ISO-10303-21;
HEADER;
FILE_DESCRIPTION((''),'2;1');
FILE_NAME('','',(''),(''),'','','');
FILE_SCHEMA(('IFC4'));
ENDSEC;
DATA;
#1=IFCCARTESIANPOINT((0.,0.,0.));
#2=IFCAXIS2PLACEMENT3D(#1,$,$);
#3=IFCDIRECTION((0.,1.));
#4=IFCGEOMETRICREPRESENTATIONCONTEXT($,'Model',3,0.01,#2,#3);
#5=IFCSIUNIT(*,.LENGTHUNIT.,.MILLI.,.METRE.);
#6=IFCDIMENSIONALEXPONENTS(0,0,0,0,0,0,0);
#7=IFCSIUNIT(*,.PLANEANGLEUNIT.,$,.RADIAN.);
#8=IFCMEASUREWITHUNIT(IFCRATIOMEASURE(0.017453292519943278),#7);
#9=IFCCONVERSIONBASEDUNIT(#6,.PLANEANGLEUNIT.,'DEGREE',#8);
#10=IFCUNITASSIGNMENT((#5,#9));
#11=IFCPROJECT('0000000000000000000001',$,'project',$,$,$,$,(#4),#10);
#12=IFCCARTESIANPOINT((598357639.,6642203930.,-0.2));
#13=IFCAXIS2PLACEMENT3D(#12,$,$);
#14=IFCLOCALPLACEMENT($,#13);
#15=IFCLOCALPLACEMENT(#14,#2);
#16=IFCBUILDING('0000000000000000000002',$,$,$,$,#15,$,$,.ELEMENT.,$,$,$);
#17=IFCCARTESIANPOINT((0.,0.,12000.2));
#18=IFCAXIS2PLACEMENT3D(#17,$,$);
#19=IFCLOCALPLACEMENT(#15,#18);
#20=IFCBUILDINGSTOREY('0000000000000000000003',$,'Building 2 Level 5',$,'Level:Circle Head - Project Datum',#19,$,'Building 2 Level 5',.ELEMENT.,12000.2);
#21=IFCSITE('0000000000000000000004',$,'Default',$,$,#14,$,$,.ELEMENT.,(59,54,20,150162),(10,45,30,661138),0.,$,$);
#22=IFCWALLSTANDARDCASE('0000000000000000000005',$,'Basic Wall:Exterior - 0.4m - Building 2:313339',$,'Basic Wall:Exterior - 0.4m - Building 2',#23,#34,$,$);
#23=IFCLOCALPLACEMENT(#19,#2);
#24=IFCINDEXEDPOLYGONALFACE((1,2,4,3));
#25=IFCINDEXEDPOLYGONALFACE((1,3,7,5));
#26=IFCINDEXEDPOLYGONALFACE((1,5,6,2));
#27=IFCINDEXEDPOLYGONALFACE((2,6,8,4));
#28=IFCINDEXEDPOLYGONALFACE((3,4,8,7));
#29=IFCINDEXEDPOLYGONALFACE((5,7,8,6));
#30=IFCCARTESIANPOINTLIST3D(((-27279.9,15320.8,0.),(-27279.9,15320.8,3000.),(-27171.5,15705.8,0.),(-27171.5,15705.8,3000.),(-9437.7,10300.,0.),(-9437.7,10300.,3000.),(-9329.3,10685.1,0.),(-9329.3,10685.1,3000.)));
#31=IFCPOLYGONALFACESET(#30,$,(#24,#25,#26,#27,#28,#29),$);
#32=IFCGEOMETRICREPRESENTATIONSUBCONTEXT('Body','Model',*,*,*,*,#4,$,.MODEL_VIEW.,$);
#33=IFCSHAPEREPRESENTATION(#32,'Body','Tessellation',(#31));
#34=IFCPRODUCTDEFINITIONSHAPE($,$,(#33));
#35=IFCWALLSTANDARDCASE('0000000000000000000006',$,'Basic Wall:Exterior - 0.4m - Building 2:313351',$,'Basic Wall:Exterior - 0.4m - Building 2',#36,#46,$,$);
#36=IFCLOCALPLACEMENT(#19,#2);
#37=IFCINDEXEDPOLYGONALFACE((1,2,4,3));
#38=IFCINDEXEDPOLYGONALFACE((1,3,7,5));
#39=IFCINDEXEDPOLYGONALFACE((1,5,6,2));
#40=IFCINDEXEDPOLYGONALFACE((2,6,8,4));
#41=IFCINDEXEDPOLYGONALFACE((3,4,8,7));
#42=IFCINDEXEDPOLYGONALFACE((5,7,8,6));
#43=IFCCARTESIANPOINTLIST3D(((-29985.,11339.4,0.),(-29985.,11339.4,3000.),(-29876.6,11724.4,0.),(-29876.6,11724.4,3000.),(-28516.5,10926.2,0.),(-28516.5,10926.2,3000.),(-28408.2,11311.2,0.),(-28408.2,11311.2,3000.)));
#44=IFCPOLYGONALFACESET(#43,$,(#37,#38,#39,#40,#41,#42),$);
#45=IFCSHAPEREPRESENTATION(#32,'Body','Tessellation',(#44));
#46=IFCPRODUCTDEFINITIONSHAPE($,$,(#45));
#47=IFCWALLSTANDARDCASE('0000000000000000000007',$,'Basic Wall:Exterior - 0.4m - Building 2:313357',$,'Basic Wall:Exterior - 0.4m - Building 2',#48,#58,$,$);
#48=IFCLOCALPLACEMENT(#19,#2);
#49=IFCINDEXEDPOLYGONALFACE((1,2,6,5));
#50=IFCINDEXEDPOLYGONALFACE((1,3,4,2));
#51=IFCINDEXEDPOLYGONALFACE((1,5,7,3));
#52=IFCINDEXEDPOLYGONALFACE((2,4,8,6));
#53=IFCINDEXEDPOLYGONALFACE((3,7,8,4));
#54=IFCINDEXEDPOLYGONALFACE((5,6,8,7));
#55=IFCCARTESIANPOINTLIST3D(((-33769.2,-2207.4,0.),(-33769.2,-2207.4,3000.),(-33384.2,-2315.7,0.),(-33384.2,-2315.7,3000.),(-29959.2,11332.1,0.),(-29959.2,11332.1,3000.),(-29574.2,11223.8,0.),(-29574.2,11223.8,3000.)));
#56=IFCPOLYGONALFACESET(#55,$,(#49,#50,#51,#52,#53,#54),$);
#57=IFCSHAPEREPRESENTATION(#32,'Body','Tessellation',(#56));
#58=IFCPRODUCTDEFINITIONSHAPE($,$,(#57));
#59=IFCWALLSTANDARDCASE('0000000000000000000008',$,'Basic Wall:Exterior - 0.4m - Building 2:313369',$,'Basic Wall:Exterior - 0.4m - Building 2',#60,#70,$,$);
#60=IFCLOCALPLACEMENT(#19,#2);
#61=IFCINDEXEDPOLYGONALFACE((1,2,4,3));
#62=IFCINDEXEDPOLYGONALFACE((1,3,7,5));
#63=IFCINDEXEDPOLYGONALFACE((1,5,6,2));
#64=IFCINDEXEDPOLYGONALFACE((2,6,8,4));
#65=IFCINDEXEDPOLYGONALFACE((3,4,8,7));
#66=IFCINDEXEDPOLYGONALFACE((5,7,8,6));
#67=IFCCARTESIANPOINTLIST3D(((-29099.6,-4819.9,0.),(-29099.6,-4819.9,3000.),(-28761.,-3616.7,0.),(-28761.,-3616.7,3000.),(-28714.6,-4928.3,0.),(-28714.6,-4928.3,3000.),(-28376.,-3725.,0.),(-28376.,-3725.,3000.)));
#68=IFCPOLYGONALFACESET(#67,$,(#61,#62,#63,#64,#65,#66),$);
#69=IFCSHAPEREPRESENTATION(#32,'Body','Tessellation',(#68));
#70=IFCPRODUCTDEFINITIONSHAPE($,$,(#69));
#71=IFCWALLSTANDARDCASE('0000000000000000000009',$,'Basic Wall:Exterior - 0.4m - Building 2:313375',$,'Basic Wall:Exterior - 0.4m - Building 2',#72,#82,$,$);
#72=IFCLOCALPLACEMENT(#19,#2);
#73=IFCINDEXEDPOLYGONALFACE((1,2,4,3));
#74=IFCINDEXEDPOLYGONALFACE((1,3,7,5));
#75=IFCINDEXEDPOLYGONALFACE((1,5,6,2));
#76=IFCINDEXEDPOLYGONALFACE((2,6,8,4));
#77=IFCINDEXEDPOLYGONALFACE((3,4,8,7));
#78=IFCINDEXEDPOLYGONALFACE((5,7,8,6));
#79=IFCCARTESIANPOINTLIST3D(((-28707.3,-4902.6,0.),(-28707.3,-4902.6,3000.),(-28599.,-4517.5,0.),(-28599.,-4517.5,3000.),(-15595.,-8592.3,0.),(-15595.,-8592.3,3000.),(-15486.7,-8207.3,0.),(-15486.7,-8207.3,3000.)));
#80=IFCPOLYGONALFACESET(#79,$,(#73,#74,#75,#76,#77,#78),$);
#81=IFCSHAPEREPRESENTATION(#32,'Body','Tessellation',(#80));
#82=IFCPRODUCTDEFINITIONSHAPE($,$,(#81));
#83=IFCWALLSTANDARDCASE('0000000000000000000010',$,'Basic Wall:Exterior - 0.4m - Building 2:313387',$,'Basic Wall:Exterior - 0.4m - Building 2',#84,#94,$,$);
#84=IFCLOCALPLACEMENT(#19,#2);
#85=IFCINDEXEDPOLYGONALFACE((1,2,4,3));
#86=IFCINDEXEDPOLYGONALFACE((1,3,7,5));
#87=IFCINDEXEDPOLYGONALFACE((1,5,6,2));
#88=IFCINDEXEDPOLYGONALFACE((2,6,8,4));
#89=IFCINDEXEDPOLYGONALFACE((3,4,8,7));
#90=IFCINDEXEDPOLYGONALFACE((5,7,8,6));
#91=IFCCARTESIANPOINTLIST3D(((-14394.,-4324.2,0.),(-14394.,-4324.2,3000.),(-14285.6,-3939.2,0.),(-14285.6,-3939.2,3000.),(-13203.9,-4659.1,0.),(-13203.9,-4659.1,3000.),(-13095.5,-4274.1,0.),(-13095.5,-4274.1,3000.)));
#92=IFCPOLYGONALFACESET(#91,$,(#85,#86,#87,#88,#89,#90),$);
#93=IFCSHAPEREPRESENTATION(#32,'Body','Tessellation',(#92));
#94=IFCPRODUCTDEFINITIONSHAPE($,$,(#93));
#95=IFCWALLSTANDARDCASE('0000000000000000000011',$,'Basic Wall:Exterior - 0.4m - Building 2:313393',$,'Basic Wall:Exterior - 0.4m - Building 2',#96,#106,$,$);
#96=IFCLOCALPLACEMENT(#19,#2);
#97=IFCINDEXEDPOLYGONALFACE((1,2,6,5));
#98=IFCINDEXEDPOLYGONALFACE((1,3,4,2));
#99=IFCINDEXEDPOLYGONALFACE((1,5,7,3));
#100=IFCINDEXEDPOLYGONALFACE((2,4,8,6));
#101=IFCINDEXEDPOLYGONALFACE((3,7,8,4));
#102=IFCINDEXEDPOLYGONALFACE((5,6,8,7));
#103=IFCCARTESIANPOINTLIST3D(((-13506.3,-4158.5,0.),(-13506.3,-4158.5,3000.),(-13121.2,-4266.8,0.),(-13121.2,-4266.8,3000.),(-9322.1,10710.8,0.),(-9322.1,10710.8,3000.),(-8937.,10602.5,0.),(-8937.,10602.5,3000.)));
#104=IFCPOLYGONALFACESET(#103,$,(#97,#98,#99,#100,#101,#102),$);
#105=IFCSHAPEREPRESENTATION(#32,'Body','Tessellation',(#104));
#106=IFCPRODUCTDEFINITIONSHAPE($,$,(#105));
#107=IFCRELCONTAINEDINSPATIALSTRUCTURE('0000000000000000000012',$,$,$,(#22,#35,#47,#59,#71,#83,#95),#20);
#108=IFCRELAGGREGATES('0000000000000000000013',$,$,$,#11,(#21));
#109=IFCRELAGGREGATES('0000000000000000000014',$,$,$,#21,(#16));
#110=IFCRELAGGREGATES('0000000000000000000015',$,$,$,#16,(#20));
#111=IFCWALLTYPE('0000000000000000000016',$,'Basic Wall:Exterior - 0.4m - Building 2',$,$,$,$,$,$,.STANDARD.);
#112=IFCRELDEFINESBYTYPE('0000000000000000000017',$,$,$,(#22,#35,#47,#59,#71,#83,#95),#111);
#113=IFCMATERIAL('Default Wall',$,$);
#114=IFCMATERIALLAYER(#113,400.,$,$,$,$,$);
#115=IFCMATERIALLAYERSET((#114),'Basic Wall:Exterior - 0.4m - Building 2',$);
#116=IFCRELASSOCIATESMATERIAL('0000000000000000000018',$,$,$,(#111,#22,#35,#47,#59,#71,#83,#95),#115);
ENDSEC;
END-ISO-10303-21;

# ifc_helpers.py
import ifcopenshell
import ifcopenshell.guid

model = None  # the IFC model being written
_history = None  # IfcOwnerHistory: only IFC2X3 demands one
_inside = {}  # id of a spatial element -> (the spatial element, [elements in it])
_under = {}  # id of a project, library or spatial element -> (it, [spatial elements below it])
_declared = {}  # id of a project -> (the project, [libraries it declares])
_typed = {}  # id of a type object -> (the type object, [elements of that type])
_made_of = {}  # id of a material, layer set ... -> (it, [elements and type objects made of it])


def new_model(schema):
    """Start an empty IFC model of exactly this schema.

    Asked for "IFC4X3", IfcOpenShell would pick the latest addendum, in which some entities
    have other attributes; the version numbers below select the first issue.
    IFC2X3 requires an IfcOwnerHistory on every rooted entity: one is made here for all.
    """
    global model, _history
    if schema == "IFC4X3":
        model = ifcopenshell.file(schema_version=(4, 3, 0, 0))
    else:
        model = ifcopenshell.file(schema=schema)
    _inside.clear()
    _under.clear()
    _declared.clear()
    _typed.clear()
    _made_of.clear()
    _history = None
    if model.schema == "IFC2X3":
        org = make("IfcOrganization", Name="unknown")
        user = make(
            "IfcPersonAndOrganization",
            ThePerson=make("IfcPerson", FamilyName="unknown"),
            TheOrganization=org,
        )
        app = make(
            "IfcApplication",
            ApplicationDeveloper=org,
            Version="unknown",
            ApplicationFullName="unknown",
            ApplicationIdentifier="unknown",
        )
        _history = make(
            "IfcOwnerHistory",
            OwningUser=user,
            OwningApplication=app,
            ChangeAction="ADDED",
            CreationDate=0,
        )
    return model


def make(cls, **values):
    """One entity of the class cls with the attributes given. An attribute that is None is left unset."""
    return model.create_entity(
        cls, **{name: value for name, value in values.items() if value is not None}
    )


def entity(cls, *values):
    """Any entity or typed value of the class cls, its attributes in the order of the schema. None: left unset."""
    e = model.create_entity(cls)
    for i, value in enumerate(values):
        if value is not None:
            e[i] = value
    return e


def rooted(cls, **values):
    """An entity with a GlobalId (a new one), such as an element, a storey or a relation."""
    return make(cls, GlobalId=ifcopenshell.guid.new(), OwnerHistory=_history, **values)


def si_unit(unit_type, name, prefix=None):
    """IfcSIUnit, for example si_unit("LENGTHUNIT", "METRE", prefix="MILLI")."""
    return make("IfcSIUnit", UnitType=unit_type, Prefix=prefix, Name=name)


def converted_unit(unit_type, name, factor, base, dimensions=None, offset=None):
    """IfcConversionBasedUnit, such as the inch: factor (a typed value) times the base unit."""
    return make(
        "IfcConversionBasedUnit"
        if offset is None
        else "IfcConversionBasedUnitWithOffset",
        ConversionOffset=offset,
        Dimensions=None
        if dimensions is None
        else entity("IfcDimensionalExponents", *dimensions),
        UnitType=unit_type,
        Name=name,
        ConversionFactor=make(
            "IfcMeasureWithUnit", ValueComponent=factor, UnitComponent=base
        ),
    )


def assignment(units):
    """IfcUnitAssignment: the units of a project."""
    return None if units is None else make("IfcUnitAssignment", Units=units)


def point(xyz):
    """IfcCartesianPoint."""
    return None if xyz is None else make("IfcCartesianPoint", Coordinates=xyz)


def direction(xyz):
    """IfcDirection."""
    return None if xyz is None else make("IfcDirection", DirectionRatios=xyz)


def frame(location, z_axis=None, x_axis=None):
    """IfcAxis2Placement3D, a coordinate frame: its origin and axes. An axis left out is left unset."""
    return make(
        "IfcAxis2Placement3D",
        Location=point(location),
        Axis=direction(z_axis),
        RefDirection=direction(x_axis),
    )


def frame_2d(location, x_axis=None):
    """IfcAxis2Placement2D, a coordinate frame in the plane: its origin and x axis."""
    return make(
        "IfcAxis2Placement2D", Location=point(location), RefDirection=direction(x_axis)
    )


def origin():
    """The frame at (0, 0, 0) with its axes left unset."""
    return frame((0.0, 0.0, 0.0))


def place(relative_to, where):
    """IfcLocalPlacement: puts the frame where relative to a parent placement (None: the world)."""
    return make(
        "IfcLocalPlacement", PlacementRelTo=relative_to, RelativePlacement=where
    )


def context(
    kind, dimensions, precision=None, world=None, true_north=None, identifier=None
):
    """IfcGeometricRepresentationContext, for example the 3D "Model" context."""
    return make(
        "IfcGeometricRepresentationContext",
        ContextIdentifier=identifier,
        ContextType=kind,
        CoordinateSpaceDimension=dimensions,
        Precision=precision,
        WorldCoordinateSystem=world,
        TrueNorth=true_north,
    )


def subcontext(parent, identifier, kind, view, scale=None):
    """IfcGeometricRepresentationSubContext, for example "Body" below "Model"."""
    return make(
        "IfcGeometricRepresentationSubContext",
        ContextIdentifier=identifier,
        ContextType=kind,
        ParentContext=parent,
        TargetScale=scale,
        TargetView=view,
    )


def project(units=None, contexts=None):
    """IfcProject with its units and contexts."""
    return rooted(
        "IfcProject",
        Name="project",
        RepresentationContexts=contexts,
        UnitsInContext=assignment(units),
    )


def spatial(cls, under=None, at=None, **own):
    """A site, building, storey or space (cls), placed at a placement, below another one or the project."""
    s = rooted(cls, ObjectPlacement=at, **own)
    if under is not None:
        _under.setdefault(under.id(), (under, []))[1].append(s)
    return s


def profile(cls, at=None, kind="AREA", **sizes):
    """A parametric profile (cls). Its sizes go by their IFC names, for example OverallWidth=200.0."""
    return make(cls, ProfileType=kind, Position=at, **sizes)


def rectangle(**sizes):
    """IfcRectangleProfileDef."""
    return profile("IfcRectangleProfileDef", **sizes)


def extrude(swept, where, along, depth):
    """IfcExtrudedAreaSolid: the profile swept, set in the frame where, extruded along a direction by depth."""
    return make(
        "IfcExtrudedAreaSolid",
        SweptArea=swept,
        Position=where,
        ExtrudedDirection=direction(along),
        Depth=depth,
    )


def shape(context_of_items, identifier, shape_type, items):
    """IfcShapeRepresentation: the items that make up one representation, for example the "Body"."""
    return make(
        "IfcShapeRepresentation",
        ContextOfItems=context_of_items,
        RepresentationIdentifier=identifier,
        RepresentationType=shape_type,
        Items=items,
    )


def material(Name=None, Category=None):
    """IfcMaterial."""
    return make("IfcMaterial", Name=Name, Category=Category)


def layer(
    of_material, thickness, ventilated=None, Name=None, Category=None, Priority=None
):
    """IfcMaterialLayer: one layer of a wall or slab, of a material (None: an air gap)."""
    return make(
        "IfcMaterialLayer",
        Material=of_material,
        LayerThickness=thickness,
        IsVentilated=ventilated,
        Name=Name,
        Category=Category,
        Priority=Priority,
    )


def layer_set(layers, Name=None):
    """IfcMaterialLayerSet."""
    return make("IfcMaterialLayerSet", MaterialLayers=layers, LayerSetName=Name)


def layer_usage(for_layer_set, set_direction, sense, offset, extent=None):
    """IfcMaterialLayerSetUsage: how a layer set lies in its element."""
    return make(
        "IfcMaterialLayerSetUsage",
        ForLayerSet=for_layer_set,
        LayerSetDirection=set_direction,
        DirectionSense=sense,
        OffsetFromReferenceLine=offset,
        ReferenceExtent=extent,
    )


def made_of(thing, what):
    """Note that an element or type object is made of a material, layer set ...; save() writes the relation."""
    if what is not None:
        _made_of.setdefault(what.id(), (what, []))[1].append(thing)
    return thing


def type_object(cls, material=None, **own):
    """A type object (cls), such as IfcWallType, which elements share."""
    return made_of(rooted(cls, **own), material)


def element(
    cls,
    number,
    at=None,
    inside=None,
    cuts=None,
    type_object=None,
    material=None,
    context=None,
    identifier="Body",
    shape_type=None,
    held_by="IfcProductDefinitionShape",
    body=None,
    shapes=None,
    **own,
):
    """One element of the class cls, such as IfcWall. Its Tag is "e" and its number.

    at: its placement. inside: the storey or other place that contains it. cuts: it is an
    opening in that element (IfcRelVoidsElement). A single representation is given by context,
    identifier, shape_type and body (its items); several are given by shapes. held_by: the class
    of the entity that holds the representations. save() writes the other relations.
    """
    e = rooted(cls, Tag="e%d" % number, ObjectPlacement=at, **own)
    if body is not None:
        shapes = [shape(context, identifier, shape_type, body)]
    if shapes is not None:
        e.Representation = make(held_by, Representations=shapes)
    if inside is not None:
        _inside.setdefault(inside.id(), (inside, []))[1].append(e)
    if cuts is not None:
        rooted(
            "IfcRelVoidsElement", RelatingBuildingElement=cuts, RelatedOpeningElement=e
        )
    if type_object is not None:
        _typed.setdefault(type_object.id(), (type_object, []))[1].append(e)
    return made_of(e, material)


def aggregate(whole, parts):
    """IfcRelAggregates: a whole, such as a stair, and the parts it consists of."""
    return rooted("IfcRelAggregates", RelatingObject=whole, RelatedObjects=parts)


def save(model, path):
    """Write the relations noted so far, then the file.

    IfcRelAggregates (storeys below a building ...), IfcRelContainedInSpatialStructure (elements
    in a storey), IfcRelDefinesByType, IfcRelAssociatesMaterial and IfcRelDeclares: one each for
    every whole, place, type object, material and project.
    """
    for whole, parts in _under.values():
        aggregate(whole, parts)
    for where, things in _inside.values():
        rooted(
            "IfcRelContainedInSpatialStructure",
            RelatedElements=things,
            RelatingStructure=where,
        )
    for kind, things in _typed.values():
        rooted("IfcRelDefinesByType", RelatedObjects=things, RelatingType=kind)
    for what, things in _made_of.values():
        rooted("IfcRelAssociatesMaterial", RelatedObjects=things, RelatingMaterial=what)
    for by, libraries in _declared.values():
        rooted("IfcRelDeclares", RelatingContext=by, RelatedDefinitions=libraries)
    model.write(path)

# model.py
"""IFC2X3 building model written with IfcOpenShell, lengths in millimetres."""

from ifc_helpers import new_model, entity, si_unit, converted_unit, direction, frame, frame_2d, origin, place, context, subcontext, project, spatial, rectangle, extrude, material, layer, layer_set, layer_usage, type_object, element, save


model = new_model("IFC2X3")

# Units and contexts
model_context = context("Model", 3, precision=0.01, world=origin(), true_north=direction((0.0, 1.0)))
body_context = subcontext(model_context, "Body", "Model", "MODEL_VIEW")
ifc_project = project(units=[si_unit("LENGTHUNIT", "METRE", prefix="MILLI"), converted_unit("PLANEANGLEUNIT", "DEGREE", entity("IfcRatioMeasure", 0.017453292519943278), si_unit("PLANEANGLEUNIT", "RADIAN"), dimensions=[0, 0, 0, 0, 0, 0, 0])], contexts=[model_context])

# Site, building, storey
site_placement = place(None, frame((598357639.0, 6642203930.0, -0.2)))
site = spatial("IfcSite", under=ifc_project, at=site_placement, Name="Default", CompositionType="ELEMENT", RefLatitude=(59, 54, 20, 150162), RefLongitude=(10, 45, 30, 661138), RefElevation=0.0)
building_placement = place(site_placement, origin())
building = spatial("IfcBuilding", under=site, at=building_placement, CompositionType="ELEMENT")
storey_placement = place(building_placement, frame((0.0, 0.0, 12000.2)))
storey = spatial("IfcBuildingStorey", under=building, at=storey_placement, Name="Building 2 Level 5", ObjectType="Level:Circle Head - Project Datum", LongName="Building 2 Level 5", CompositionType="ELEMENT", Elevation=12000.2)

# Walls
ifc_material_1 = material(Name="Default Wall")
ifc_layer_1 = layer(ifc_material_1, 400.0)
ifc_layer_set_1 = layer_set([ifc_layer_1], Name="Basic Wall:Exterior - 0.4m - Building 2")
ifc_layer_usage_1 = layer_usage(ifc_layer_set_1, "AXIS2", "POSITIVE", -200.0)
wall_type = type_object("IfcWallType", Name="Basic Wall:Exterior - 0.4m - Building 2", PredefinedType="STANDARD", material=ifc_layer_set_1)
wall_1_placement = place(storey_placement, frame((-9383.5, 10492.6, 0.0), z_axis=(0.0, 0.0, 1.0), x_axis=(-0.962614, 0.270878, 0.0)))
element("IfcWallStandardCase", 1, at=wall_1_placement, inside=storey, type_object=wall_type, material=ifc_layer_usage_1, Name="Basic Wall:Exterior - 0.4m - Building 2:313339", ObjectType="Basic Wall:Exterior - 0.4m - Building 2", context=body_context, shape_type="SweptSolid", body=[
    extrude(rectangle(XDim=18535.1, YDim=400.0, at=frame_2d((9267.6, 0.0), x_axis=(-1.0, 0.0))), origin(), (0.0, 0.0, 1.0), 3000.0),
])
wall_2_placement = place(storey_placement, frame((-28462.3, 11118.7, 0.0), z_axis=(0.0, 0.0, 1.0), x_axis=(-0.962614, 0.270878, 0.0)))
element("IfcWallStandardCase", 2, at=wall_2_placement, inside=storey, type_object=wall_type, material=ifc_layer_usage_1, Name="Basic Wall:Exterior - 0.4m - Building 2:313351", ObjectType="Basic Wall:Exterior - 0.4m - Building 2", context=body_context, shape_type="SweptSolid", body=[
    extrude(rectangle(XDim=1525.5, YDim=400.0, at=frame_2d((762.7, 0.0), x_axis=(-1.0, 0.0))), origin(), (0.0, 0.0, 1.0), 3000.0),
])
wall_3_placement = place(storey_placement, frame((-29766.7, 11278.0, 0.0), z_axis=(0.0, 0.0, 1.0), x_axis=(-0.270878, -0.962614, 0.0)))
element("IfcWallStandardCase", 3, at=wall_3_placement, inside=storey, type_object=wall_type, material=ifc_layer_usage_1, Name="Basic Wall:Exterior - 0.4m - Building 2:313357", ObjectType="Basic Wall:Exterior - 0.4m - Building 2", context=body_context, shape_type="SweptSolid", body=[
    extrude(rectangle(XDim=14065.4, YDim=400.0, at=frame_2d((7032.7, 0.0), x_axis=(-1.0, 0.0))), origin(), (0.0, 0.0, 1.0), 3000.0),
])
wall_4_placement = place(storey_placement, frame((-28568.5, -3670.8, 0.0), z_axis=(0.0, 0.0, 1.0), x_axis=(-0.270878, -0.962614, 0.0)))
element("IfcWallStandardCase", 4, at=wall_4_placement, inside=storey, type_object=wall_type, material=ifc_layer_usage_1, Name="Basic Wall:Exterior - 0.4m - Building 2:313369", ObjectType="Basic Wall:Exterior - 0.4m - Building 2", context=body_context, shape_type="SweptSolid", body=[
    extrude(rectangle(XDim=1250.0, YDim=400.0, at=frame_2d((625.0, 0.0), x_axis=(-1.0, 0.0))), origin(), (0.0, 0.0, 1.0), 3000.0),
])
wall_5_placement = place(storey_placement, frame((-28653.2, -4710.0, 0.0), z_axis=(0.0, 0.0, 1.0), x_axis=(0.962614, -0.270878, 0.0)))
element("IfcWallStandardCase", 5, at=wall_5_placement, inside=storey, type_object=wall_type, material=ifc_layer_usage_1, Name="Basic Wall:Exterior - 0.4m - Building 2:313375", ObjectType="Basic Wall:Exterior - 0.4m - Building 2", context=body_context, shape_type="SweptSolid", body=[
    extrude(rectangle(XDim=13621.6, YDim=400.0, at=frame_2d((6810.8, 0.0), x_axis=(-1.0, 0.0))), origin(), (0.0, 0.0, 1.0), 3000.0),
])
wall_6_placement = place(storey_placement, frame((-14339.8, -4131.7, 0.0), z_axis=(0.0, 0.0, 1.0), x_axis=(0.962614, -0.270878, 0.0)))
element("IfcWallStandardCase", 6, at=wall_6_placement, inside=storey, type_object=wall_type, material=ifc_layer_usage_1, Name="Basic Wall:Exterior - 0.4m - Building 2:313387", ObjectType="Basic Wall:Exterior - 0.4m - Building 2", context=body_context, shape_type="SweptSolid", body=[
    extrude(rectangle(XDim=1236.4, YDim=400.0, at=frame_2d((618.2, 0.0), x_axis=(-1.0, 0.0))), origin(), (0.0, 0.0, 1.0), 3000.0),
])
wall_7_placement = place(storey_placement, frame((-13313.8, -4212.6, 0.0), z_axis=(0.0, 0.0, 1.0), x_axis=(0.270878, 0.962614, 0.0)))
element("IfcWallStandardCase", 7, at=wall_7_placement, inside=storey, type_object=wall_type, material=ifc_layer_usage_1, Name="Basic Wall:Exterior - 0.4m - Building 2:313393", ObjectType="Basic Wall:Exterior - 0.4m - Building 2", context=body_context, shape_type="SweptSolid", body=[
    extrude(rectangle(XDim=15446.8, YDim=400.0, at=frame_2d((7723.4, 0.0), x_axis=(-1.0, 0.0))), origin(), (0.0, 0.0, 1.0), 3000.0),
])

save(model, "model.ifc")
